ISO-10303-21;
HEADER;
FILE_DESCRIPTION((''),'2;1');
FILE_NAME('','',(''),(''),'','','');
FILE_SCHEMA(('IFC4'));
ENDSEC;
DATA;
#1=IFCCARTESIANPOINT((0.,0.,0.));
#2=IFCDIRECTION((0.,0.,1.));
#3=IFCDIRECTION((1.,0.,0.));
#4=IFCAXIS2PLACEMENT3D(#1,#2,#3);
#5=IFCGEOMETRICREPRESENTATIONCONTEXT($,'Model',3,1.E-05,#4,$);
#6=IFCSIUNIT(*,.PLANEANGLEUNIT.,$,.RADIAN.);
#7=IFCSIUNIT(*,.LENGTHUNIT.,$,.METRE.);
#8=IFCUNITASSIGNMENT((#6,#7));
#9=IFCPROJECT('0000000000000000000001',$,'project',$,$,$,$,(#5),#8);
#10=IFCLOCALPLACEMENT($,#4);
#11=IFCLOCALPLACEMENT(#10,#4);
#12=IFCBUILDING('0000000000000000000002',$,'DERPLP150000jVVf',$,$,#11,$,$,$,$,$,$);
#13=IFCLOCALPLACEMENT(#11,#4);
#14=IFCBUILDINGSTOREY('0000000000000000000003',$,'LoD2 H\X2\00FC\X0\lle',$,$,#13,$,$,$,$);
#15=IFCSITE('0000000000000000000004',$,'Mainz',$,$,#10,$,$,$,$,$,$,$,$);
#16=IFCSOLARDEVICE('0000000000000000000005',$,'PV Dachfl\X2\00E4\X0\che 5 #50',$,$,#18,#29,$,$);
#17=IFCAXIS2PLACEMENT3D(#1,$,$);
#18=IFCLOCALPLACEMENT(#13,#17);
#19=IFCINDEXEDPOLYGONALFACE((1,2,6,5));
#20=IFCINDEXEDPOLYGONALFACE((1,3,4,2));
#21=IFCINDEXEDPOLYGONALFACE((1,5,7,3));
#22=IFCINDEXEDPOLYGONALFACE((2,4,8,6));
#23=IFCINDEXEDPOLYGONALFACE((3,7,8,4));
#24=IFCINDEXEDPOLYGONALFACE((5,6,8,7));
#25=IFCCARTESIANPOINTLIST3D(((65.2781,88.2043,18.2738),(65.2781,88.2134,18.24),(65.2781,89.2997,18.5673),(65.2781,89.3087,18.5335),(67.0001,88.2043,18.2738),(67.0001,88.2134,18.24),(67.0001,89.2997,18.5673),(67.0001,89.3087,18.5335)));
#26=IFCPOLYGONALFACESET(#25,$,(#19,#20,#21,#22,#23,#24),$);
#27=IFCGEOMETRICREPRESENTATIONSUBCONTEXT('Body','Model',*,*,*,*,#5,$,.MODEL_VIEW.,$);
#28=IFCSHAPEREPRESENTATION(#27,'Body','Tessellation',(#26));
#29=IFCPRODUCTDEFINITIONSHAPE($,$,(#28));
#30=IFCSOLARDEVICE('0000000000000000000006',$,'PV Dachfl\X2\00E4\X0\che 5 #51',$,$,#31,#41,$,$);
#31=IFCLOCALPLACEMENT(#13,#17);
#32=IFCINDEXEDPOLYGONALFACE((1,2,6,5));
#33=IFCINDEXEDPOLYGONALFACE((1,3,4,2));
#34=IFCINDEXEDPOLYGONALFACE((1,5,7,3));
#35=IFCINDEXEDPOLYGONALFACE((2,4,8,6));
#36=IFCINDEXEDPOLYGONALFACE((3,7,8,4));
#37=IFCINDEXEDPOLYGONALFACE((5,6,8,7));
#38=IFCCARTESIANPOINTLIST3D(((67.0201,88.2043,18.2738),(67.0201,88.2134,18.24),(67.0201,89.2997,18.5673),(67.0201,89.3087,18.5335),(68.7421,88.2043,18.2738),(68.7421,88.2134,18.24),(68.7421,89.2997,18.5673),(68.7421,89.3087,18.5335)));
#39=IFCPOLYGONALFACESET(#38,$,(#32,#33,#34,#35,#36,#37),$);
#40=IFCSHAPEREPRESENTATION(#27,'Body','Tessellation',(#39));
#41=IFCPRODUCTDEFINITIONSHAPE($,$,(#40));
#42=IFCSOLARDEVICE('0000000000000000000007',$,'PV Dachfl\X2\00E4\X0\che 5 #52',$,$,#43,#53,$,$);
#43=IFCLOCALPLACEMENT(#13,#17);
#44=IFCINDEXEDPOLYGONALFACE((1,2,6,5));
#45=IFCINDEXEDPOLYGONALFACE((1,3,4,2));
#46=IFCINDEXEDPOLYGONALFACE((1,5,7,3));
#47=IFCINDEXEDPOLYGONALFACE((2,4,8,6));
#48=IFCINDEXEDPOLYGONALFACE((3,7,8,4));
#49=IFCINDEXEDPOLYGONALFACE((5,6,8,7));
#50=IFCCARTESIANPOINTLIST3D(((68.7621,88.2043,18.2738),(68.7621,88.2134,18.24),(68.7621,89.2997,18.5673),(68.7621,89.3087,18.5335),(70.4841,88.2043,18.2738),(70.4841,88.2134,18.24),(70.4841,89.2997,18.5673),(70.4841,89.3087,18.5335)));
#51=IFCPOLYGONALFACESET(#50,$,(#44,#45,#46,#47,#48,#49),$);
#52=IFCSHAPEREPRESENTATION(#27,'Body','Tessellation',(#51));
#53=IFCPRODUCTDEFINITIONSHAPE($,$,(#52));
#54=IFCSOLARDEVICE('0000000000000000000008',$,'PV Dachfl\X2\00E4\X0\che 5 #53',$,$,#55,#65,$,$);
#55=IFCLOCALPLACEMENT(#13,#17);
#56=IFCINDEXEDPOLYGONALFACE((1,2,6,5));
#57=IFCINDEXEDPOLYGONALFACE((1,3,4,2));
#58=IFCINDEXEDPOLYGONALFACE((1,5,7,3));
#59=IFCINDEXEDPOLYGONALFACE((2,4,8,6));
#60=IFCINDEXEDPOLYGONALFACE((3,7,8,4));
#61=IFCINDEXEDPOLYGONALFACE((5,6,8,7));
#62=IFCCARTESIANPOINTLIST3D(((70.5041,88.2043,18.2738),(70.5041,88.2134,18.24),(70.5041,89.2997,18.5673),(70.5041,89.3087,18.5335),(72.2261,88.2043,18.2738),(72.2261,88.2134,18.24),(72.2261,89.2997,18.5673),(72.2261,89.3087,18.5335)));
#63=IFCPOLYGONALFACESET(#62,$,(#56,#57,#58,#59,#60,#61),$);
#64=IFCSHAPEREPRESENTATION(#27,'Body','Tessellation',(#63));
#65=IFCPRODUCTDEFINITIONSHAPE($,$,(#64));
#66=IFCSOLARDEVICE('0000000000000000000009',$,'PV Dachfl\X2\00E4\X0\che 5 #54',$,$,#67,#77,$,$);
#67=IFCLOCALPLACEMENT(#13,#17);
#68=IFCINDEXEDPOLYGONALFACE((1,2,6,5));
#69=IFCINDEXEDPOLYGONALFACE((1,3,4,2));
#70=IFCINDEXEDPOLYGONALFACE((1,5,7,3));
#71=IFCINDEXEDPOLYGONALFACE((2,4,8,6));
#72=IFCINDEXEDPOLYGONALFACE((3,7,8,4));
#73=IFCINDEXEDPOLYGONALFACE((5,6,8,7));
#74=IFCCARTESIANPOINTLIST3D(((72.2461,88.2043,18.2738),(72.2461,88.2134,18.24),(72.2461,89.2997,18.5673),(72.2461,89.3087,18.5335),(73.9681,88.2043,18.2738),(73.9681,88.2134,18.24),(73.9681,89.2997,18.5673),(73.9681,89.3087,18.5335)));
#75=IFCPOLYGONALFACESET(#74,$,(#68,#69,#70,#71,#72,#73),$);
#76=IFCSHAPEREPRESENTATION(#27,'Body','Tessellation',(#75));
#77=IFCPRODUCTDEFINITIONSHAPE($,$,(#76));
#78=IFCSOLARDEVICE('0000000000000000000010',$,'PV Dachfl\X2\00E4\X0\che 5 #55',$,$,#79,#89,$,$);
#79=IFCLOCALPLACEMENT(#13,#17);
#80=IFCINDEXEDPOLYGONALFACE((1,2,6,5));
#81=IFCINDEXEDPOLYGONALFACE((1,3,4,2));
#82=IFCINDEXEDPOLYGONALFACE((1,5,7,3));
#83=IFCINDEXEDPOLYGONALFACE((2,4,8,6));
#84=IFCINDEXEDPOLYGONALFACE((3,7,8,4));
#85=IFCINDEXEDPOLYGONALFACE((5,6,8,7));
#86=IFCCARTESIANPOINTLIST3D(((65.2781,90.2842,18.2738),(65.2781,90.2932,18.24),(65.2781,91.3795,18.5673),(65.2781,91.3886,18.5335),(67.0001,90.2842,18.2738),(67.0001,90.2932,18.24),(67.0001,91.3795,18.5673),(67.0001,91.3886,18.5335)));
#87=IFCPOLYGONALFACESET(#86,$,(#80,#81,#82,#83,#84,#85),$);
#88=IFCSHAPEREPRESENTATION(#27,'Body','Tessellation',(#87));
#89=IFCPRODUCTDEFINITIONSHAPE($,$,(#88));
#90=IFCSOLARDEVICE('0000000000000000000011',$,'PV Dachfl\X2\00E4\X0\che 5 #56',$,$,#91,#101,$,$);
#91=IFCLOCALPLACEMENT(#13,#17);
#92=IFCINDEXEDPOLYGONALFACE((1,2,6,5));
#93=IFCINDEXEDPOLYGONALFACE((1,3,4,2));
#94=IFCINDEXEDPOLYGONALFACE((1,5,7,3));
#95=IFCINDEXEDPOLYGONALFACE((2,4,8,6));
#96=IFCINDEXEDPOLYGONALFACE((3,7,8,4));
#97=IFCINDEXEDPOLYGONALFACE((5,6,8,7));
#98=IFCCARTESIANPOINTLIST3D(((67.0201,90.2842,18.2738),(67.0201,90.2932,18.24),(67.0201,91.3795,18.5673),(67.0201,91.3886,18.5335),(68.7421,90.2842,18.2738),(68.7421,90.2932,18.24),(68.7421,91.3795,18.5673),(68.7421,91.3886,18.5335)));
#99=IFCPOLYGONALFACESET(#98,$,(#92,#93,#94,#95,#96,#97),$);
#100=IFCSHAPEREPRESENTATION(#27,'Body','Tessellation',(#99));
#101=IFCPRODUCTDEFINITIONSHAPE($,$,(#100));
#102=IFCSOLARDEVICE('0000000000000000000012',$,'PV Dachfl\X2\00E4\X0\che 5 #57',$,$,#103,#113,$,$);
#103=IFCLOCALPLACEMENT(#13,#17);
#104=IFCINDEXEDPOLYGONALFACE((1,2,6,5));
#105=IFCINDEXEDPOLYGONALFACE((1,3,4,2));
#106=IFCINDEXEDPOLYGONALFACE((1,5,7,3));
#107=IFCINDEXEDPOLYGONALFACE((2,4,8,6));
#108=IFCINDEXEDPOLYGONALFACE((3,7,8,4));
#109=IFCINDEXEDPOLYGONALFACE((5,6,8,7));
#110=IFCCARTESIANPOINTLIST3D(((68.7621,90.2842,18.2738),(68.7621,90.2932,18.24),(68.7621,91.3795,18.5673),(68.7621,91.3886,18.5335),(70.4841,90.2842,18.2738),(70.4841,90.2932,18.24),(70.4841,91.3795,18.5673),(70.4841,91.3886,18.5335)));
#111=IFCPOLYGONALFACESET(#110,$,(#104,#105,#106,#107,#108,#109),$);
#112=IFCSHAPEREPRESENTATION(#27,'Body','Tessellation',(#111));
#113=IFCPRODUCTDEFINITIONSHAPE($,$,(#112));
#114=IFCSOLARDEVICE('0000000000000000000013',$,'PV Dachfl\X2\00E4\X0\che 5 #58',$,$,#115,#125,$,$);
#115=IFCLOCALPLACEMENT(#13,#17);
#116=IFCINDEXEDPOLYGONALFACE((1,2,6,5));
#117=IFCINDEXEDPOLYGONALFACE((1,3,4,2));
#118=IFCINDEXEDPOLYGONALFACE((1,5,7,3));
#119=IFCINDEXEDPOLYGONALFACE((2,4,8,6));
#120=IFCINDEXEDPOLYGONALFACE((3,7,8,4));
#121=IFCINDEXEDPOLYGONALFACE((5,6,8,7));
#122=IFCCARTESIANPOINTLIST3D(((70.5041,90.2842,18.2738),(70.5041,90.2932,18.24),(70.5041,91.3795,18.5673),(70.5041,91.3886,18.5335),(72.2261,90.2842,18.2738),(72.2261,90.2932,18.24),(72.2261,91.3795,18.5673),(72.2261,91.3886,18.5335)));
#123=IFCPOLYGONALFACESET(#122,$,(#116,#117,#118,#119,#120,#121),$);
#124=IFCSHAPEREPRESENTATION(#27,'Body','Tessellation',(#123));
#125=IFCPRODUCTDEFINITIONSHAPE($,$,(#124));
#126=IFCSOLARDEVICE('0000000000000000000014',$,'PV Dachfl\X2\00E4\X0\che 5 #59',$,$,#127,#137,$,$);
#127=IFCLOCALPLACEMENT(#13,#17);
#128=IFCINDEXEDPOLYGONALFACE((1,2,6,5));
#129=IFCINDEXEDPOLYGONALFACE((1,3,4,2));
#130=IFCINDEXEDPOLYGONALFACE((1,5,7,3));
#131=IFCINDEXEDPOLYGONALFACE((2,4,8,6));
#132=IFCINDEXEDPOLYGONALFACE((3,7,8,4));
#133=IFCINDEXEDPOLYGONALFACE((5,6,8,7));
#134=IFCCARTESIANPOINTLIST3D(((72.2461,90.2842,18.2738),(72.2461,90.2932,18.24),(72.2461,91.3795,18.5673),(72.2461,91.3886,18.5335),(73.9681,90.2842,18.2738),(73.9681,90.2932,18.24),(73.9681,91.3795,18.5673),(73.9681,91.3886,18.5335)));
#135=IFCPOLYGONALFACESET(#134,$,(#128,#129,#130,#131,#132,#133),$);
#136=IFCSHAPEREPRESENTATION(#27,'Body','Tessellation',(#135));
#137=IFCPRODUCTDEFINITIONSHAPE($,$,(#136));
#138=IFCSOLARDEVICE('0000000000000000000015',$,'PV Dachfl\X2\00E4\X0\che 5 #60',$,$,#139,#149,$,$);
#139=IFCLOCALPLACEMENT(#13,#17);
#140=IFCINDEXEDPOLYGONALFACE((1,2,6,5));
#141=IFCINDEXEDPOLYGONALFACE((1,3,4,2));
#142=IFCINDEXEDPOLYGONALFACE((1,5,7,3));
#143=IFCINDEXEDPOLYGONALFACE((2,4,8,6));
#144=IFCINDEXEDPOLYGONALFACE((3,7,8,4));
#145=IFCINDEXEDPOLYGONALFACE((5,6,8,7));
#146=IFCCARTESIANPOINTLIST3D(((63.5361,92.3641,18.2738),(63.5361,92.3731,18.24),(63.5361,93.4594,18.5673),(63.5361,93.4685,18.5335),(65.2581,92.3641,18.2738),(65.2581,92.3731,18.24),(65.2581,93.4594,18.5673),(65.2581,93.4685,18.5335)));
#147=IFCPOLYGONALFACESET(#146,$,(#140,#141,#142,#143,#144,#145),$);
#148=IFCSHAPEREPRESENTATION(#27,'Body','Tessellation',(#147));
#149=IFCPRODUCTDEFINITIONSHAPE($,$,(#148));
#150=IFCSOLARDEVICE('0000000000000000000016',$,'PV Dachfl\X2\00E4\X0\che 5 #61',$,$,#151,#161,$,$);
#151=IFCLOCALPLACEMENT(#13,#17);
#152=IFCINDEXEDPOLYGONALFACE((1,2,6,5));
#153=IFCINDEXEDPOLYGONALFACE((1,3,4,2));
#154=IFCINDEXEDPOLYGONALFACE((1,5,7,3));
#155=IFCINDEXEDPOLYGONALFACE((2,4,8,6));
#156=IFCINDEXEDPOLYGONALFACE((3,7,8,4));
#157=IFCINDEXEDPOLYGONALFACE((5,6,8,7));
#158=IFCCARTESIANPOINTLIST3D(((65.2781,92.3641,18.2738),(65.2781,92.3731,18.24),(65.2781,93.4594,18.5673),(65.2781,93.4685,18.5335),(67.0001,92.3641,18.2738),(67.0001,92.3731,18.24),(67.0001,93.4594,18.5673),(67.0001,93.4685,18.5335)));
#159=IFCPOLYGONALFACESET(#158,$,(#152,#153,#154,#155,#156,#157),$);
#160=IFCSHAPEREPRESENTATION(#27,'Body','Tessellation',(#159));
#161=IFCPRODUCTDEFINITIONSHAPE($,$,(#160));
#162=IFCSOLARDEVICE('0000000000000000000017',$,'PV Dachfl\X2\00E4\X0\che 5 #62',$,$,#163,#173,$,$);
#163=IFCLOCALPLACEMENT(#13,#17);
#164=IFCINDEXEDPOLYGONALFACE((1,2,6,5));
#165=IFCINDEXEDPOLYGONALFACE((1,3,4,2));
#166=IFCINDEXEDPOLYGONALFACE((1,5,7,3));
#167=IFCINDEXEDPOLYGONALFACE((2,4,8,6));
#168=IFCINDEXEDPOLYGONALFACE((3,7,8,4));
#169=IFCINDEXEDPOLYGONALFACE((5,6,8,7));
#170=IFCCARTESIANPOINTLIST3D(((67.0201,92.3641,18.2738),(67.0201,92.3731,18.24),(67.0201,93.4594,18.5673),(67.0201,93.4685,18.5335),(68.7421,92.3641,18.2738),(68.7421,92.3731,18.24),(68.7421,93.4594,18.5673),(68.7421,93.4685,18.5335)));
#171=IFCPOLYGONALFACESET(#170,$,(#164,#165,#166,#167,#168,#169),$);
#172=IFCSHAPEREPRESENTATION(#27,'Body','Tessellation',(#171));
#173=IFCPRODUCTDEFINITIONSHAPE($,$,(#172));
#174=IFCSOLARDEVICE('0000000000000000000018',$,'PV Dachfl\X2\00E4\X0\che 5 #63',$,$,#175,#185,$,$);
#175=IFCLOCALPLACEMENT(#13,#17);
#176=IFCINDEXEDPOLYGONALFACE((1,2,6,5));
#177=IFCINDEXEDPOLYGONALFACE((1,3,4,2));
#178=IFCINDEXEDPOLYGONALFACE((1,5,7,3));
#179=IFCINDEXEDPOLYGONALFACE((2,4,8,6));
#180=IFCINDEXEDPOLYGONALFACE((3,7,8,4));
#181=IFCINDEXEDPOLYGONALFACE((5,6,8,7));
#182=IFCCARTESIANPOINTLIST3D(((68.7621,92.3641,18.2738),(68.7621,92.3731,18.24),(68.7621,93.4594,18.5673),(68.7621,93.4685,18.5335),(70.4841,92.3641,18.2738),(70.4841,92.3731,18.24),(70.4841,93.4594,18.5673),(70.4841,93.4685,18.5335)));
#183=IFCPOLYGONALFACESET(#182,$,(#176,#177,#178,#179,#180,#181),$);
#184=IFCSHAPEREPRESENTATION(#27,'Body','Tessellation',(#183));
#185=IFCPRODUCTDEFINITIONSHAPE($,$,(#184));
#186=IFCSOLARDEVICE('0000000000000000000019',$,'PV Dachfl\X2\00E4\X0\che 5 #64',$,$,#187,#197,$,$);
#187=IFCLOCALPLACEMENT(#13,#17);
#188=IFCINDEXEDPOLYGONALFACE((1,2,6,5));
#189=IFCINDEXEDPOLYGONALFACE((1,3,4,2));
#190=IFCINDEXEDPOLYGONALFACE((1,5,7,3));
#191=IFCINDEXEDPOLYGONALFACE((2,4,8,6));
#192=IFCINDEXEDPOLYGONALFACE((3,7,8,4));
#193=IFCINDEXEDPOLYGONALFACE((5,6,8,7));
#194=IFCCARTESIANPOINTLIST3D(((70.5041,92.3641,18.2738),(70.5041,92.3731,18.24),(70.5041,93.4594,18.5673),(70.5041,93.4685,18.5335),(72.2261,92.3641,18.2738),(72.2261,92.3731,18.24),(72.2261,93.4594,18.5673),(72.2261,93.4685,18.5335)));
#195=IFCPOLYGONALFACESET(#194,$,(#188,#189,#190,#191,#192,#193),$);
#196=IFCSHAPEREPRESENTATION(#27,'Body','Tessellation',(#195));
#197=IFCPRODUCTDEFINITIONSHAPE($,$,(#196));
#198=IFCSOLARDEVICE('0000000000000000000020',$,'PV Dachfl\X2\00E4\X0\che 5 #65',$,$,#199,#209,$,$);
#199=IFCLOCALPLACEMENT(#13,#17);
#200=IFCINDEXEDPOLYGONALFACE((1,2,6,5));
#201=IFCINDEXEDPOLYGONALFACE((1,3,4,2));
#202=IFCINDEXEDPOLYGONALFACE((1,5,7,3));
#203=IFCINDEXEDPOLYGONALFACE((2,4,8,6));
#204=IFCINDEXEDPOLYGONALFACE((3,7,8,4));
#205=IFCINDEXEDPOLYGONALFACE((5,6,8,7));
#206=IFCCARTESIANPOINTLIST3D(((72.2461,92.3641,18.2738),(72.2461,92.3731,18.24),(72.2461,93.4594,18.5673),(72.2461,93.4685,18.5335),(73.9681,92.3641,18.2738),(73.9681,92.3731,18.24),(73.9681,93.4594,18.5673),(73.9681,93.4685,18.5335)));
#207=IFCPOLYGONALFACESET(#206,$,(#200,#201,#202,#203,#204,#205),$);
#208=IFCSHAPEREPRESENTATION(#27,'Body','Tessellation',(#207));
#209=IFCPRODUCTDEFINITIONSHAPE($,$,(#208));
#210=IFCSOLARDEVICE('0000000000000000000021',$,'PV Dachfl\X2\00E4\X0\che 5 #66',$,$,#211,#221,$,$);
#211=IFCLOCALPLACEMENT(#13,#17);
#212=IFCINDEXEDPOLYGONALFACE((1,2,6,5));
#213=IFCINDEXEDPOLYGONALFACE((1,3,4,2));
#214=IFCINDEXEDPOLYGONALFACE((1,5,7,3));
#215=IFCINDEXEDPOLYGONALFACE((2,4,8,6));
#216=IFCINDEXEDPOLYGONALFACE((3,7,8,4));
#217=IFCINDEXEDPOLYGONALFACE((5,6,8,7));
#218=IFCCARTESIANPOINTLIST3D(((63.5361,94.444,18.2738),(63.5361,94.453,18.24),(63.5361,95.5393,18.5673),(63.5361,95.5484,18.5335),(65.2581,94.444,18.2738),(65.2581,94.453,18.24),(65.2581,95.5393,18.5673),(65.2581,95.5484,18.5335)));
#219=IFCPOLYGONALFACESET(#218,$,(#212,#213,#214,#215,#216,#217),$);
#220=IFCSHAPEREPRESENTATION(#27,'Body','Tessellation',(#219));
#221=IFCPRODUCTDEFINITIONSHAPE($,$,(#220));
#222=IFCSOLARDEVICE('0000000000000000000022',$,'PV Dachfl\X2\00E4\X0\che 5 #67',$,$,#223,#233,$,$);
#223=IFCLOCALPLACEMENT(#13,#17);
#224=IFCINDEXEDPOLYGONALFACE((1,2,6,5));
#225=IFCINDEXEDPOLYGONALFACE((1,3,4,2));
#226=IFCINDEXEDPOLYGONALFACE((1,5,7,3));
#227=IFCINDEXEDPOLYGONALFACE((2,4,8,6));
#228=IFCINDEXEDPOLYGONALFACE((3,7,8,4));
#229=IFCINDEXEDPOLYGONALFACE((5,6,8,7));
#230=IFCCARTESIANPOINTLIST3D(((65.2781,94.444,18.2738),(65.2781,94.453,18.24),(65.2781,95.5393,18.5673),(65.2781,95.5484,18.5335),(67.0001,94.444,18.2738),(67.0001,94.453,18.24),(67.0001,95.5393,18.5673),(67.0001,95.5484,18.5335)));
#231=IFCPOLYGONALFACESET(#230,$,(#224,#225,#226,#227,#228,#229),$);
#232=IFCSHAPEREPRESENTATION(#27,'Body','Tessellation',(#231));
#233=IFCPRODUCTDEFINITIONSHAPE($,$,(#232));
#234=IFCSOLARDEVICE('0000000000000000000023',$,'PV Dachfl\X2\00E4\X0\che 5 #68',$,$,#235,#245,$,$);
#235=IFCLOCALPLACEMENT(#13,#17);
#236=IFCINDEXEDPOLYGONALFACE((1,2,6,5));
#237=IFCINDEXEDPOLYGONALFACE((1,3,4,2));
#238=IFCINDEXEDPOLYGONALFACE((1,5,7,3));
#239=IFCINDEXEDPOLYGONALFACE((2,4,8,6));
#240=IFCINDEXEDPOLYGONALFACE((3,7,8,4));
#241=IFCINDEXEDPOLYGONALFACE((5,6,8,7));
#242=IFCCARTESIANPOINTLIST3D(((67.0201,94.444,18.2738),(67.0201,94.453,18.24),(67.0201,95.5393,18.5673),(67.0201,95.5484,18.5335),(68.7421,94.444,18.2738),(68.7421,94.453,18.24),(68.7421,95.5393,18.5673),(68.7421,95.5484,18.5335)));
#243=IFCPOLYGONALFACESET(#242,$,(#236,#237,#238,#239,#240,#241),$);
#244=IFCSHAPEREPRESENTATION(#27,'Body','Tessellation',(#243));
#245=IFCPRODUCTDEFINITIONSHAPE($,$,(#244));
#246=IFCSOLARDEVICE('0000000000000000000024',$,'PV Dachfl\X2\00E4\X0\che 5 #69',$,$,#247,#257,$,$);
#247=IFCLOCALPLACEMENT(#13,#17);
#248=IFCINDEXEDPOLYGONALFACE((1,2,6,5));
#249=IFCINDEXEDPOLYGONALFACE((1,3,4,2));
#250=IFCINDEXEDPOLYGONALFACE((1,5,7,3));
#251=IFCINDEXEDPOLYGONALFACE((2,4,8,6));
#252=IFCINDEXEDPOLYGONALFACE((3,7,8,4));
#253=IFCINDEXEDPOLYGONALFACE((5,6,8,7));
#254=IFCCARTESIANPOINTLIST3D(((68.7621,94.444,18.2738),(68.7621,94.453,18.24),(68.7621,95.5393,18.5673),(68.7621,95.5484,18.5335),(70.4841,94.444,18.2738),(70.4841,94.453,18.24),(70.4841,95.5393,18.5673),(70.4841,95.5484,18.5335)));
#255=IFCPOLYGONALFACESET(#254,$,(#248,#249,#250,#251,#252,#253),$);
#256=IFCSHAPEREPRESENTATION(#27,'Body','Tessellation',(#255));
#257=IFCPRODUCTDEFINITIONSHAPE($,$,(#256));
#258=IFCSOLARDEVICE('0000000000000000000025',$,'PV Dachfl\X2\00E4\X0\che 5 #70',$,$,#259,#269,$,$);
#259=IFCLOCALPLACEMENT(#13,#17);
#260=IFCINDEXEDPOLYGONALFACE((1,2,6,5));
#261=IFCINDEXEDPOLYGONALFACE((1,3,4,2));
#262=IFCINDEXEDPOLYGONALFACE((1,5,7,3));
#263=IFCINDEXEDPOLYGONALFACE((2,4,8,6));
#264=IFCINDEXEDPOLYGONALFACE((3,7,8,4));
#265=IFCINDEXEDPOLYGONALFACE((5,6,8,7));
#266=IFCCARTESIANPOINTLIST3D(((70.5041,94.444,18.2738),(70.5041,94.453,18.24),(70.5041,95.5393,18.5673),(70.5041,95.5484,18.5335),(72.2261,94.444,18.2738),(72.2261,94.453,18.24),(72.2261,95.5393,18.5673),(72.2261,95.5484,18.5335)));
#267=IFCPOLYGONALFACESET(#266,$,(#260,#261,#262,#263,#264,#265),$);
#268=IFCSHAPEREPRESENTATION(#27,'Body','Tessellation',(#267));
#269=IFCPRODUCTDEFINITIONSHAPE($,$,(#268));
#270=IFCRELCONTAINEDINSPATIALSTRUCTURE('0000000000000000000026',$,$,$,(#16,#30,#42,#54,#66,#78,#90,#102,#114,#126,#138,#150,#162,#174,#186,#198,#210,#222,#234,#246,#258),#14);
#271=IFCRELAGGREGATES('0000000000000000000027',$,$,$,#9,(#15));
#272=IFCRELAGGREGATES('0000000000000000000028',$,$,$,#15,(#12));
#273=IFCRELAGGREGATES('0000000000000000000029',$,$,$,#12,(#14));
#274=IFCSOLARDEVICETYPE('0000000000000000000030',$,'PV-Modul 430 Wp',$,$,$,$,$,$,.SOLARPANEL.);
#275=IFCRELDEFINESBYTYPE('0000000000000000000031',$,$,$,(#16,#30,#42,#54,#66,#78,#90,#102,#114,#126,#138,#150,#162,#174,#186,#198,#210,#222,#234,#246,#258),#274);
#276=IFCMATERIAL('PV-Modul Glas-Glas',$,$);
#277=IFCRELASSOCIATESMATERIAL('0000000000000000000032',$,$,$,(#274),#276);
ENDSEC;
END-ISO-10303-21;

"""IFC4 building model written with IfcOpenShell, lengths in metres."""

from ifc_helpers import new_model, si_unit, frame, frame_2d, origin, origin_with_axes, place, context, subcontext, project, spatial, rectangle, extrude, source, transform, mapped, material, type_object, type_shapes, element, save


model = new_model("IFC4")

# Units and contexts
model_context = context("Model", 3, precision=1e-05, world=origin_with_axes())
body_context = subcontext(model_context, "Body", "Model", "MODEL_VIEW")
ifc_project = project(units=[si_unit("PLANEANGLEUNIT", "RADIAN"), si_unit("LENGTHUNIT", "METRE")], contexts=[model_context])

# Site, building, storey
site_placement = place(None, origin_with_axes())
site = spatial("IfcSite", under=ifc_project, at=site_placement, Name="Mainz")
building_placement = place(site_placement, origin_with_axes())
building = spatial("IfcBuilding", under=site, at=building_placement, Name="DERPLP150000jVVf")
storey_placement = place(building_placement, origin_with_axes())
storey = spatial("IfcBuildingStorey", under=building, at=storey_placement, Name="LoD2 Hülle")

# Solar devices
ifc_material = material(Name="PV-Modul Glas-Glas")
solar_device_type = type_object("IfcSolarDeviceType", Name="PV-Modul 430 Wp", PredefinedType="SOLARPANEL", material=ifc_material)
shared_shape = source(origin_with_axes(), body_context, "Body", "SweptSolid", [
    extrude(rectangle(XDim=1.722, YDim=1.134, at=frame_2d((0.861, 0.567))), origin(), (0.0, 0.0, 1.0), 0.035),
])
type_shapes(solar_device_type, [shared_shape])
for number, where, z_axis, x_axis, name in (
    (1, (65.2781, 88.2134, 18.24), (0.0, -0.258819, 0.965926), (1.0, 0.0, 0.0), "PV Dachfläche 5 #50"),
    (2, (67.0201, 88.2134, 18.24), (0.0, -0.258819, 0.965926), (1.0, 0.0, 0.0), "PV Dachfläche 5 #51"),
    (3, (68.7621, 88.2134, 18.24), (0.0, -0.258819, 0.965926), (1.0, 0.0, 0.0), "PV Dachfläche 5 #52"),
    (4, (70.5041, 88.2134, 18.24), (0.0, -0.258819, 0.965926), (1.0, 0.0, 0.0), "PV Dachfläche 5 #53"),
    (5, (72.2461, 88.2134, 18.24), (0.0, -0.258819, 0.965926), (1.0, 0.0, 0.0), "PV Dachfläche 5 #54"),
    (6, (65.2781, 90.2932, 18.24), (0.0, -0.258819, 0.965926), (1.0, 0.0, 0.0), "PV Dachfläche 5 #55"),
    (7, (67.0201, 90.2932, 18.24), (0.0, -0.258819, 0.965926), (1.0, 0.0, 0.0), "PV Dachfläche 5 #56"),
    (8, (68.7621, 90.2932, 18.24), (0.0, -0.258819, 0.965926), (1.0, 0.0, 0.0), "PV Dachfläche 5 #57"),
    (9, (70.5041, 90.2932, 18.24), (0.0, -0.258819, 0.965926), (1.0, 0.0, 0.0), "PV Dachfläche 5 #58"),
    (10, (72.2461, 90.2932, 18.24), (0.0, -0.258819, 0.965926), (1.0, 0.0, 0.0), "PV Dachfläche 5 #59"),
    (11, (63.5361, 92.3731, 18.24), (0.0, -0.258819, 0.965926), (1.0, 0.0, 0.0), "PV Dachfläche 5 #60"),
    (12, (65.2781, 92.3731, 18.24), (0.0, -0.258819, 0.965926), (1.0, 0.0, 0.0), "PV Dachfläche 5 #61"),
    (13, (67.0201, 92.3731, 18.24), (0.0, -0.258819, 0.965926), (1.0, 0.0, 0.0), "PV Dachfläche 5 #62"),
    (14, (68.7621, 92.3731, 18.24), (0.0, -0.258819, 0.965926), (1.0, 0.0, 0.0), "PV Dachfläche 5 #63"),
    (15, (70.5041, 92.3731, 18.24), (0.0, -0.258819, 0.965926), (1.0, 0.0, 0.0), "PV Dachfläche 5 #64"),
    (16, (72.2461, 92.3731, 18.24), (0.0, -0.258819, 0.965926), (1.0, 0.0, 0.0), "PV Dachfläche 5 #65"),
    (17, (63.5361, 94.453, 18.24), (0.0, -0.258819, 0.965926), (1.0, 0.0, 0.0), "PV Dachfläche 5 #66"),
    (18, (65.2781, 94.453, 18.24), (0.0, -0.258819, 0.965926), (1.0, 0.0, 0.0), "PV Dachfläche 5 #67"),
    (19, (67.0201, 94.453, 18.24), (0.0, -0.258819, 0.965926), (1.0, 0.0, 0.0), "PV Dachfläche 5 #68"),
    (20, (68.7621, 94.453, 18.24), (0.0, -0.258819, 0.965926), (1.0, 0.0, 0.0), "PV Dachfläche 5 #69"),
    (21, (70.5041, 94.453, 18.24), (0.0, -0.258819, 0.965926), (1.0, 0.0, 0.0), "PV Dachfläche 5 #70"),
):
    element("IfcSolarDevice", number, at=place(storey_placement, frame(where, z_axis=z_axis, x_axis=x_axis)), inside=storey, type_object=solar_device_type, Name=name, context=body_context, shape_type="MappedRepresentation", body=[
        mapped(shared_shape, transform((0.0, 0.0, 0.0), x_axis=(1.0, 0.0, 0.0), y_axis=(0.0, 1.0, 0.0), z_axis=(0.0, 0.0, 1.0), scale=1.0)),
    ])

save(model, "model.ifc")
